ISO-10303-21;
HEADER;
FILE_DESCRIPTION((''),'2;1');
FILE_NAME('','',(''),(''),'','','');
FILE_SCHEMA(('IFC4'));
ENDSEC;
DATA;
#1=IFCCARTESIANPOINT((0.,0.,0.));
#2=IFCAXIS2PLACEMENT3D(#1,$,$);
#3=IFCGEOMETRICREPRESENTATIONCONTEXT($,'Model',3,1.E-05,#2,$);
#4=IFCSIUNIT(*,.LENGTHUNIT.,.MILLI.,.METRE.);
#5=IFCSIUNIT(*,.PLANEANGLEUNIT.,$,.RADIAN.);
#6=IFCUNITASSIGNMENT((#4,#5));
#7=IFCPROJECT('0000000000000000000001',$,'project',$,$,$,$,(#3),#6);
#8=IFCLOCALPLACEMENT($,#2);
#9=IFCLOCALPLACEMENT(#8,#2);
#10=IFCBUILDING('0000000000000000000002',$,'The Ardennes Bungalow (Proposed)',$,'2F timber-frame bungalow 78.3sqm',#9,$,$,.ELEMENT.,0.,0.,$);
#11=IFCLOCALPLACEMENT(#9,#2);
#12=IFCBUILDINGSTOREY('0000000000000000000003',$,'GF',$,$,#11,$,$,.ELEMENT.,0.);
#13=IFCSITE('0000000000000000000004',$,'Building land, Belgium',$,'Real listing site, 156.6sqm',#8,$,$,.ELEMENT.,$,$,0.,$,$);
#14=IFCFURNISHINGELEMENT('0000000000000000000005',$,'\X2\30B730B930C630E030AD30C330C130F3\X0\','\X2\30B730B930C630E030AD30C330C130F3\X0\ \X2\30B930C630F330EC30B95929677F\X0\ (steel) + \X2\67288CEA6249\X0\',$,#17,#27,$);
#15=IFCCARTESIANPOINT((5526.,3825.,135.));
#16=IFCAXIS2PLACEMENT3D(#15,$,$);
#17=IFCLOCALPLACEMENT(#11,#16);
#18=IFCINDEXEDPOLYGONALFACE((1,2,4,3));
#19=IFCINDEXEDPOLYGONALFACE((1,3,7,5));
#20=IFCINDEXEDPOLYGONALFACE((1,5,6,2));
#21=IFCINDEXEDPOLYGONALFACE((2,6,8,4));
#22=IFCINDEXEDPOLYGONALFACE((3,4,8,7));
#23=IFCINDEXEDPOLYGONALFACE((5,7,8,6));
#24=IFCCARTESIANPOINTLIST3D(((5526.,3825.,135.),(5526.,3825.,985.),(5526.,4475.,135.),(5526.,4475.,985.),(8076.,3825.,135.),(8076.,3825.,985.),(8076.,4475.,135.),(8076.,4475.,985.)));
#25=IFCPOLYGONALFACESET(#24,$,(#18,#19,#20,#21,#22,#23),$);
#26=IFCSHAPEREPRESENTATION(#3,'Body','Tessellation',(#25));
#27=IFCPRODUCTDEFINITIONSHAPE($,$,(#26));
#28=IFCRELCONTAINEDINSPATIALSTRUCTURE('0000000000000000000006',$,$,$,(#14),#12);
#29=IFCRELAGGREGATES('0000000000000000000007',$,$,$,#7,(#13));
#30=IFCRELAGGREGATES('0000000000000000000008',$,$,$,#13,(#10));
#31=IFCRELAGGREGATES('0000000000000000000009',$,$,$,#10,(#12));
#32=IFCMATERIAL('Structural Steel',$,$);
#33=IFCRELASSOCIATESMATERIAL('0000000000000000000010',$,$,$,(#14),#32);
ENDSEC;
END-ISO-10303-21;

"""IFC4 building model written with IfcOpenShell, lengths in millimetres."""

from ifc_helpers import new_model, si_unit, frame, frame_2d, origin, place, context, project, spatial, rectangle, extrude, material, element, save


model = new_model("IFC4")

# Units and contexts
model_context = context("Model", 3, precision=1e-05, world=origin())
ifc_project = project(units=[si_unit("LENGTHUNIT", "METRE", prefix="MILLI"), si_unit("PLANEANGLEUNIT", "RADIAN")], contexts=[model_context])

# Site, building, storey
site_placement = place(None, origin())
site = spatial("IfcSite", under=ifc_project, at=site_placement, Name="Building land, Belgium", ObjectType="Real listing site, 156.6sqm", CompositionType="ELEMENT", RefElevation=0.0)
building_placement = place(site_placement, origin())
building = spatial("IfcBuilding", under=site, at=building_placement, Name="The Ardennes Bungalow (Proposed)", ObjectType="2F timber-frame bungalow 78.3sqm", CompositionType="ELEMENT", ElevationOfRefHeight=0.0, ElevationOfTerrain=0.0)
storey_placement = place(building_placement, origin())
storey = spatial("IfcBuildingStorey", under=building, at=storey_placement, Name="GF", CompositionType="ELEMENT", Elevation=0.0)

# Furnishing element
ifc_material_1 = material(Name="Structural Steel")
furnishing_1_placement = place(storey_placement, frame((5526.0, 3825.0, 135.0)))
element("IfcFurnishingElement", 1, at=furnishing_1_placement, inside=storey, material=ifc_material_1, Name="システムキッチン", Description="システムキッチン ステンレス天板 (steel) + 木質扉", context=model_context, shape_type="SweptSolid", body=[
    extrude(rectangle(XDim=2550.0, YDim=650.0, at=frame_2d((1275.0, 325.0))), frame((5526.0, 3825.0, 135.0)), (0.0, 0.0, 1.0), 850.0),
])

save(model, "model.ifc")
